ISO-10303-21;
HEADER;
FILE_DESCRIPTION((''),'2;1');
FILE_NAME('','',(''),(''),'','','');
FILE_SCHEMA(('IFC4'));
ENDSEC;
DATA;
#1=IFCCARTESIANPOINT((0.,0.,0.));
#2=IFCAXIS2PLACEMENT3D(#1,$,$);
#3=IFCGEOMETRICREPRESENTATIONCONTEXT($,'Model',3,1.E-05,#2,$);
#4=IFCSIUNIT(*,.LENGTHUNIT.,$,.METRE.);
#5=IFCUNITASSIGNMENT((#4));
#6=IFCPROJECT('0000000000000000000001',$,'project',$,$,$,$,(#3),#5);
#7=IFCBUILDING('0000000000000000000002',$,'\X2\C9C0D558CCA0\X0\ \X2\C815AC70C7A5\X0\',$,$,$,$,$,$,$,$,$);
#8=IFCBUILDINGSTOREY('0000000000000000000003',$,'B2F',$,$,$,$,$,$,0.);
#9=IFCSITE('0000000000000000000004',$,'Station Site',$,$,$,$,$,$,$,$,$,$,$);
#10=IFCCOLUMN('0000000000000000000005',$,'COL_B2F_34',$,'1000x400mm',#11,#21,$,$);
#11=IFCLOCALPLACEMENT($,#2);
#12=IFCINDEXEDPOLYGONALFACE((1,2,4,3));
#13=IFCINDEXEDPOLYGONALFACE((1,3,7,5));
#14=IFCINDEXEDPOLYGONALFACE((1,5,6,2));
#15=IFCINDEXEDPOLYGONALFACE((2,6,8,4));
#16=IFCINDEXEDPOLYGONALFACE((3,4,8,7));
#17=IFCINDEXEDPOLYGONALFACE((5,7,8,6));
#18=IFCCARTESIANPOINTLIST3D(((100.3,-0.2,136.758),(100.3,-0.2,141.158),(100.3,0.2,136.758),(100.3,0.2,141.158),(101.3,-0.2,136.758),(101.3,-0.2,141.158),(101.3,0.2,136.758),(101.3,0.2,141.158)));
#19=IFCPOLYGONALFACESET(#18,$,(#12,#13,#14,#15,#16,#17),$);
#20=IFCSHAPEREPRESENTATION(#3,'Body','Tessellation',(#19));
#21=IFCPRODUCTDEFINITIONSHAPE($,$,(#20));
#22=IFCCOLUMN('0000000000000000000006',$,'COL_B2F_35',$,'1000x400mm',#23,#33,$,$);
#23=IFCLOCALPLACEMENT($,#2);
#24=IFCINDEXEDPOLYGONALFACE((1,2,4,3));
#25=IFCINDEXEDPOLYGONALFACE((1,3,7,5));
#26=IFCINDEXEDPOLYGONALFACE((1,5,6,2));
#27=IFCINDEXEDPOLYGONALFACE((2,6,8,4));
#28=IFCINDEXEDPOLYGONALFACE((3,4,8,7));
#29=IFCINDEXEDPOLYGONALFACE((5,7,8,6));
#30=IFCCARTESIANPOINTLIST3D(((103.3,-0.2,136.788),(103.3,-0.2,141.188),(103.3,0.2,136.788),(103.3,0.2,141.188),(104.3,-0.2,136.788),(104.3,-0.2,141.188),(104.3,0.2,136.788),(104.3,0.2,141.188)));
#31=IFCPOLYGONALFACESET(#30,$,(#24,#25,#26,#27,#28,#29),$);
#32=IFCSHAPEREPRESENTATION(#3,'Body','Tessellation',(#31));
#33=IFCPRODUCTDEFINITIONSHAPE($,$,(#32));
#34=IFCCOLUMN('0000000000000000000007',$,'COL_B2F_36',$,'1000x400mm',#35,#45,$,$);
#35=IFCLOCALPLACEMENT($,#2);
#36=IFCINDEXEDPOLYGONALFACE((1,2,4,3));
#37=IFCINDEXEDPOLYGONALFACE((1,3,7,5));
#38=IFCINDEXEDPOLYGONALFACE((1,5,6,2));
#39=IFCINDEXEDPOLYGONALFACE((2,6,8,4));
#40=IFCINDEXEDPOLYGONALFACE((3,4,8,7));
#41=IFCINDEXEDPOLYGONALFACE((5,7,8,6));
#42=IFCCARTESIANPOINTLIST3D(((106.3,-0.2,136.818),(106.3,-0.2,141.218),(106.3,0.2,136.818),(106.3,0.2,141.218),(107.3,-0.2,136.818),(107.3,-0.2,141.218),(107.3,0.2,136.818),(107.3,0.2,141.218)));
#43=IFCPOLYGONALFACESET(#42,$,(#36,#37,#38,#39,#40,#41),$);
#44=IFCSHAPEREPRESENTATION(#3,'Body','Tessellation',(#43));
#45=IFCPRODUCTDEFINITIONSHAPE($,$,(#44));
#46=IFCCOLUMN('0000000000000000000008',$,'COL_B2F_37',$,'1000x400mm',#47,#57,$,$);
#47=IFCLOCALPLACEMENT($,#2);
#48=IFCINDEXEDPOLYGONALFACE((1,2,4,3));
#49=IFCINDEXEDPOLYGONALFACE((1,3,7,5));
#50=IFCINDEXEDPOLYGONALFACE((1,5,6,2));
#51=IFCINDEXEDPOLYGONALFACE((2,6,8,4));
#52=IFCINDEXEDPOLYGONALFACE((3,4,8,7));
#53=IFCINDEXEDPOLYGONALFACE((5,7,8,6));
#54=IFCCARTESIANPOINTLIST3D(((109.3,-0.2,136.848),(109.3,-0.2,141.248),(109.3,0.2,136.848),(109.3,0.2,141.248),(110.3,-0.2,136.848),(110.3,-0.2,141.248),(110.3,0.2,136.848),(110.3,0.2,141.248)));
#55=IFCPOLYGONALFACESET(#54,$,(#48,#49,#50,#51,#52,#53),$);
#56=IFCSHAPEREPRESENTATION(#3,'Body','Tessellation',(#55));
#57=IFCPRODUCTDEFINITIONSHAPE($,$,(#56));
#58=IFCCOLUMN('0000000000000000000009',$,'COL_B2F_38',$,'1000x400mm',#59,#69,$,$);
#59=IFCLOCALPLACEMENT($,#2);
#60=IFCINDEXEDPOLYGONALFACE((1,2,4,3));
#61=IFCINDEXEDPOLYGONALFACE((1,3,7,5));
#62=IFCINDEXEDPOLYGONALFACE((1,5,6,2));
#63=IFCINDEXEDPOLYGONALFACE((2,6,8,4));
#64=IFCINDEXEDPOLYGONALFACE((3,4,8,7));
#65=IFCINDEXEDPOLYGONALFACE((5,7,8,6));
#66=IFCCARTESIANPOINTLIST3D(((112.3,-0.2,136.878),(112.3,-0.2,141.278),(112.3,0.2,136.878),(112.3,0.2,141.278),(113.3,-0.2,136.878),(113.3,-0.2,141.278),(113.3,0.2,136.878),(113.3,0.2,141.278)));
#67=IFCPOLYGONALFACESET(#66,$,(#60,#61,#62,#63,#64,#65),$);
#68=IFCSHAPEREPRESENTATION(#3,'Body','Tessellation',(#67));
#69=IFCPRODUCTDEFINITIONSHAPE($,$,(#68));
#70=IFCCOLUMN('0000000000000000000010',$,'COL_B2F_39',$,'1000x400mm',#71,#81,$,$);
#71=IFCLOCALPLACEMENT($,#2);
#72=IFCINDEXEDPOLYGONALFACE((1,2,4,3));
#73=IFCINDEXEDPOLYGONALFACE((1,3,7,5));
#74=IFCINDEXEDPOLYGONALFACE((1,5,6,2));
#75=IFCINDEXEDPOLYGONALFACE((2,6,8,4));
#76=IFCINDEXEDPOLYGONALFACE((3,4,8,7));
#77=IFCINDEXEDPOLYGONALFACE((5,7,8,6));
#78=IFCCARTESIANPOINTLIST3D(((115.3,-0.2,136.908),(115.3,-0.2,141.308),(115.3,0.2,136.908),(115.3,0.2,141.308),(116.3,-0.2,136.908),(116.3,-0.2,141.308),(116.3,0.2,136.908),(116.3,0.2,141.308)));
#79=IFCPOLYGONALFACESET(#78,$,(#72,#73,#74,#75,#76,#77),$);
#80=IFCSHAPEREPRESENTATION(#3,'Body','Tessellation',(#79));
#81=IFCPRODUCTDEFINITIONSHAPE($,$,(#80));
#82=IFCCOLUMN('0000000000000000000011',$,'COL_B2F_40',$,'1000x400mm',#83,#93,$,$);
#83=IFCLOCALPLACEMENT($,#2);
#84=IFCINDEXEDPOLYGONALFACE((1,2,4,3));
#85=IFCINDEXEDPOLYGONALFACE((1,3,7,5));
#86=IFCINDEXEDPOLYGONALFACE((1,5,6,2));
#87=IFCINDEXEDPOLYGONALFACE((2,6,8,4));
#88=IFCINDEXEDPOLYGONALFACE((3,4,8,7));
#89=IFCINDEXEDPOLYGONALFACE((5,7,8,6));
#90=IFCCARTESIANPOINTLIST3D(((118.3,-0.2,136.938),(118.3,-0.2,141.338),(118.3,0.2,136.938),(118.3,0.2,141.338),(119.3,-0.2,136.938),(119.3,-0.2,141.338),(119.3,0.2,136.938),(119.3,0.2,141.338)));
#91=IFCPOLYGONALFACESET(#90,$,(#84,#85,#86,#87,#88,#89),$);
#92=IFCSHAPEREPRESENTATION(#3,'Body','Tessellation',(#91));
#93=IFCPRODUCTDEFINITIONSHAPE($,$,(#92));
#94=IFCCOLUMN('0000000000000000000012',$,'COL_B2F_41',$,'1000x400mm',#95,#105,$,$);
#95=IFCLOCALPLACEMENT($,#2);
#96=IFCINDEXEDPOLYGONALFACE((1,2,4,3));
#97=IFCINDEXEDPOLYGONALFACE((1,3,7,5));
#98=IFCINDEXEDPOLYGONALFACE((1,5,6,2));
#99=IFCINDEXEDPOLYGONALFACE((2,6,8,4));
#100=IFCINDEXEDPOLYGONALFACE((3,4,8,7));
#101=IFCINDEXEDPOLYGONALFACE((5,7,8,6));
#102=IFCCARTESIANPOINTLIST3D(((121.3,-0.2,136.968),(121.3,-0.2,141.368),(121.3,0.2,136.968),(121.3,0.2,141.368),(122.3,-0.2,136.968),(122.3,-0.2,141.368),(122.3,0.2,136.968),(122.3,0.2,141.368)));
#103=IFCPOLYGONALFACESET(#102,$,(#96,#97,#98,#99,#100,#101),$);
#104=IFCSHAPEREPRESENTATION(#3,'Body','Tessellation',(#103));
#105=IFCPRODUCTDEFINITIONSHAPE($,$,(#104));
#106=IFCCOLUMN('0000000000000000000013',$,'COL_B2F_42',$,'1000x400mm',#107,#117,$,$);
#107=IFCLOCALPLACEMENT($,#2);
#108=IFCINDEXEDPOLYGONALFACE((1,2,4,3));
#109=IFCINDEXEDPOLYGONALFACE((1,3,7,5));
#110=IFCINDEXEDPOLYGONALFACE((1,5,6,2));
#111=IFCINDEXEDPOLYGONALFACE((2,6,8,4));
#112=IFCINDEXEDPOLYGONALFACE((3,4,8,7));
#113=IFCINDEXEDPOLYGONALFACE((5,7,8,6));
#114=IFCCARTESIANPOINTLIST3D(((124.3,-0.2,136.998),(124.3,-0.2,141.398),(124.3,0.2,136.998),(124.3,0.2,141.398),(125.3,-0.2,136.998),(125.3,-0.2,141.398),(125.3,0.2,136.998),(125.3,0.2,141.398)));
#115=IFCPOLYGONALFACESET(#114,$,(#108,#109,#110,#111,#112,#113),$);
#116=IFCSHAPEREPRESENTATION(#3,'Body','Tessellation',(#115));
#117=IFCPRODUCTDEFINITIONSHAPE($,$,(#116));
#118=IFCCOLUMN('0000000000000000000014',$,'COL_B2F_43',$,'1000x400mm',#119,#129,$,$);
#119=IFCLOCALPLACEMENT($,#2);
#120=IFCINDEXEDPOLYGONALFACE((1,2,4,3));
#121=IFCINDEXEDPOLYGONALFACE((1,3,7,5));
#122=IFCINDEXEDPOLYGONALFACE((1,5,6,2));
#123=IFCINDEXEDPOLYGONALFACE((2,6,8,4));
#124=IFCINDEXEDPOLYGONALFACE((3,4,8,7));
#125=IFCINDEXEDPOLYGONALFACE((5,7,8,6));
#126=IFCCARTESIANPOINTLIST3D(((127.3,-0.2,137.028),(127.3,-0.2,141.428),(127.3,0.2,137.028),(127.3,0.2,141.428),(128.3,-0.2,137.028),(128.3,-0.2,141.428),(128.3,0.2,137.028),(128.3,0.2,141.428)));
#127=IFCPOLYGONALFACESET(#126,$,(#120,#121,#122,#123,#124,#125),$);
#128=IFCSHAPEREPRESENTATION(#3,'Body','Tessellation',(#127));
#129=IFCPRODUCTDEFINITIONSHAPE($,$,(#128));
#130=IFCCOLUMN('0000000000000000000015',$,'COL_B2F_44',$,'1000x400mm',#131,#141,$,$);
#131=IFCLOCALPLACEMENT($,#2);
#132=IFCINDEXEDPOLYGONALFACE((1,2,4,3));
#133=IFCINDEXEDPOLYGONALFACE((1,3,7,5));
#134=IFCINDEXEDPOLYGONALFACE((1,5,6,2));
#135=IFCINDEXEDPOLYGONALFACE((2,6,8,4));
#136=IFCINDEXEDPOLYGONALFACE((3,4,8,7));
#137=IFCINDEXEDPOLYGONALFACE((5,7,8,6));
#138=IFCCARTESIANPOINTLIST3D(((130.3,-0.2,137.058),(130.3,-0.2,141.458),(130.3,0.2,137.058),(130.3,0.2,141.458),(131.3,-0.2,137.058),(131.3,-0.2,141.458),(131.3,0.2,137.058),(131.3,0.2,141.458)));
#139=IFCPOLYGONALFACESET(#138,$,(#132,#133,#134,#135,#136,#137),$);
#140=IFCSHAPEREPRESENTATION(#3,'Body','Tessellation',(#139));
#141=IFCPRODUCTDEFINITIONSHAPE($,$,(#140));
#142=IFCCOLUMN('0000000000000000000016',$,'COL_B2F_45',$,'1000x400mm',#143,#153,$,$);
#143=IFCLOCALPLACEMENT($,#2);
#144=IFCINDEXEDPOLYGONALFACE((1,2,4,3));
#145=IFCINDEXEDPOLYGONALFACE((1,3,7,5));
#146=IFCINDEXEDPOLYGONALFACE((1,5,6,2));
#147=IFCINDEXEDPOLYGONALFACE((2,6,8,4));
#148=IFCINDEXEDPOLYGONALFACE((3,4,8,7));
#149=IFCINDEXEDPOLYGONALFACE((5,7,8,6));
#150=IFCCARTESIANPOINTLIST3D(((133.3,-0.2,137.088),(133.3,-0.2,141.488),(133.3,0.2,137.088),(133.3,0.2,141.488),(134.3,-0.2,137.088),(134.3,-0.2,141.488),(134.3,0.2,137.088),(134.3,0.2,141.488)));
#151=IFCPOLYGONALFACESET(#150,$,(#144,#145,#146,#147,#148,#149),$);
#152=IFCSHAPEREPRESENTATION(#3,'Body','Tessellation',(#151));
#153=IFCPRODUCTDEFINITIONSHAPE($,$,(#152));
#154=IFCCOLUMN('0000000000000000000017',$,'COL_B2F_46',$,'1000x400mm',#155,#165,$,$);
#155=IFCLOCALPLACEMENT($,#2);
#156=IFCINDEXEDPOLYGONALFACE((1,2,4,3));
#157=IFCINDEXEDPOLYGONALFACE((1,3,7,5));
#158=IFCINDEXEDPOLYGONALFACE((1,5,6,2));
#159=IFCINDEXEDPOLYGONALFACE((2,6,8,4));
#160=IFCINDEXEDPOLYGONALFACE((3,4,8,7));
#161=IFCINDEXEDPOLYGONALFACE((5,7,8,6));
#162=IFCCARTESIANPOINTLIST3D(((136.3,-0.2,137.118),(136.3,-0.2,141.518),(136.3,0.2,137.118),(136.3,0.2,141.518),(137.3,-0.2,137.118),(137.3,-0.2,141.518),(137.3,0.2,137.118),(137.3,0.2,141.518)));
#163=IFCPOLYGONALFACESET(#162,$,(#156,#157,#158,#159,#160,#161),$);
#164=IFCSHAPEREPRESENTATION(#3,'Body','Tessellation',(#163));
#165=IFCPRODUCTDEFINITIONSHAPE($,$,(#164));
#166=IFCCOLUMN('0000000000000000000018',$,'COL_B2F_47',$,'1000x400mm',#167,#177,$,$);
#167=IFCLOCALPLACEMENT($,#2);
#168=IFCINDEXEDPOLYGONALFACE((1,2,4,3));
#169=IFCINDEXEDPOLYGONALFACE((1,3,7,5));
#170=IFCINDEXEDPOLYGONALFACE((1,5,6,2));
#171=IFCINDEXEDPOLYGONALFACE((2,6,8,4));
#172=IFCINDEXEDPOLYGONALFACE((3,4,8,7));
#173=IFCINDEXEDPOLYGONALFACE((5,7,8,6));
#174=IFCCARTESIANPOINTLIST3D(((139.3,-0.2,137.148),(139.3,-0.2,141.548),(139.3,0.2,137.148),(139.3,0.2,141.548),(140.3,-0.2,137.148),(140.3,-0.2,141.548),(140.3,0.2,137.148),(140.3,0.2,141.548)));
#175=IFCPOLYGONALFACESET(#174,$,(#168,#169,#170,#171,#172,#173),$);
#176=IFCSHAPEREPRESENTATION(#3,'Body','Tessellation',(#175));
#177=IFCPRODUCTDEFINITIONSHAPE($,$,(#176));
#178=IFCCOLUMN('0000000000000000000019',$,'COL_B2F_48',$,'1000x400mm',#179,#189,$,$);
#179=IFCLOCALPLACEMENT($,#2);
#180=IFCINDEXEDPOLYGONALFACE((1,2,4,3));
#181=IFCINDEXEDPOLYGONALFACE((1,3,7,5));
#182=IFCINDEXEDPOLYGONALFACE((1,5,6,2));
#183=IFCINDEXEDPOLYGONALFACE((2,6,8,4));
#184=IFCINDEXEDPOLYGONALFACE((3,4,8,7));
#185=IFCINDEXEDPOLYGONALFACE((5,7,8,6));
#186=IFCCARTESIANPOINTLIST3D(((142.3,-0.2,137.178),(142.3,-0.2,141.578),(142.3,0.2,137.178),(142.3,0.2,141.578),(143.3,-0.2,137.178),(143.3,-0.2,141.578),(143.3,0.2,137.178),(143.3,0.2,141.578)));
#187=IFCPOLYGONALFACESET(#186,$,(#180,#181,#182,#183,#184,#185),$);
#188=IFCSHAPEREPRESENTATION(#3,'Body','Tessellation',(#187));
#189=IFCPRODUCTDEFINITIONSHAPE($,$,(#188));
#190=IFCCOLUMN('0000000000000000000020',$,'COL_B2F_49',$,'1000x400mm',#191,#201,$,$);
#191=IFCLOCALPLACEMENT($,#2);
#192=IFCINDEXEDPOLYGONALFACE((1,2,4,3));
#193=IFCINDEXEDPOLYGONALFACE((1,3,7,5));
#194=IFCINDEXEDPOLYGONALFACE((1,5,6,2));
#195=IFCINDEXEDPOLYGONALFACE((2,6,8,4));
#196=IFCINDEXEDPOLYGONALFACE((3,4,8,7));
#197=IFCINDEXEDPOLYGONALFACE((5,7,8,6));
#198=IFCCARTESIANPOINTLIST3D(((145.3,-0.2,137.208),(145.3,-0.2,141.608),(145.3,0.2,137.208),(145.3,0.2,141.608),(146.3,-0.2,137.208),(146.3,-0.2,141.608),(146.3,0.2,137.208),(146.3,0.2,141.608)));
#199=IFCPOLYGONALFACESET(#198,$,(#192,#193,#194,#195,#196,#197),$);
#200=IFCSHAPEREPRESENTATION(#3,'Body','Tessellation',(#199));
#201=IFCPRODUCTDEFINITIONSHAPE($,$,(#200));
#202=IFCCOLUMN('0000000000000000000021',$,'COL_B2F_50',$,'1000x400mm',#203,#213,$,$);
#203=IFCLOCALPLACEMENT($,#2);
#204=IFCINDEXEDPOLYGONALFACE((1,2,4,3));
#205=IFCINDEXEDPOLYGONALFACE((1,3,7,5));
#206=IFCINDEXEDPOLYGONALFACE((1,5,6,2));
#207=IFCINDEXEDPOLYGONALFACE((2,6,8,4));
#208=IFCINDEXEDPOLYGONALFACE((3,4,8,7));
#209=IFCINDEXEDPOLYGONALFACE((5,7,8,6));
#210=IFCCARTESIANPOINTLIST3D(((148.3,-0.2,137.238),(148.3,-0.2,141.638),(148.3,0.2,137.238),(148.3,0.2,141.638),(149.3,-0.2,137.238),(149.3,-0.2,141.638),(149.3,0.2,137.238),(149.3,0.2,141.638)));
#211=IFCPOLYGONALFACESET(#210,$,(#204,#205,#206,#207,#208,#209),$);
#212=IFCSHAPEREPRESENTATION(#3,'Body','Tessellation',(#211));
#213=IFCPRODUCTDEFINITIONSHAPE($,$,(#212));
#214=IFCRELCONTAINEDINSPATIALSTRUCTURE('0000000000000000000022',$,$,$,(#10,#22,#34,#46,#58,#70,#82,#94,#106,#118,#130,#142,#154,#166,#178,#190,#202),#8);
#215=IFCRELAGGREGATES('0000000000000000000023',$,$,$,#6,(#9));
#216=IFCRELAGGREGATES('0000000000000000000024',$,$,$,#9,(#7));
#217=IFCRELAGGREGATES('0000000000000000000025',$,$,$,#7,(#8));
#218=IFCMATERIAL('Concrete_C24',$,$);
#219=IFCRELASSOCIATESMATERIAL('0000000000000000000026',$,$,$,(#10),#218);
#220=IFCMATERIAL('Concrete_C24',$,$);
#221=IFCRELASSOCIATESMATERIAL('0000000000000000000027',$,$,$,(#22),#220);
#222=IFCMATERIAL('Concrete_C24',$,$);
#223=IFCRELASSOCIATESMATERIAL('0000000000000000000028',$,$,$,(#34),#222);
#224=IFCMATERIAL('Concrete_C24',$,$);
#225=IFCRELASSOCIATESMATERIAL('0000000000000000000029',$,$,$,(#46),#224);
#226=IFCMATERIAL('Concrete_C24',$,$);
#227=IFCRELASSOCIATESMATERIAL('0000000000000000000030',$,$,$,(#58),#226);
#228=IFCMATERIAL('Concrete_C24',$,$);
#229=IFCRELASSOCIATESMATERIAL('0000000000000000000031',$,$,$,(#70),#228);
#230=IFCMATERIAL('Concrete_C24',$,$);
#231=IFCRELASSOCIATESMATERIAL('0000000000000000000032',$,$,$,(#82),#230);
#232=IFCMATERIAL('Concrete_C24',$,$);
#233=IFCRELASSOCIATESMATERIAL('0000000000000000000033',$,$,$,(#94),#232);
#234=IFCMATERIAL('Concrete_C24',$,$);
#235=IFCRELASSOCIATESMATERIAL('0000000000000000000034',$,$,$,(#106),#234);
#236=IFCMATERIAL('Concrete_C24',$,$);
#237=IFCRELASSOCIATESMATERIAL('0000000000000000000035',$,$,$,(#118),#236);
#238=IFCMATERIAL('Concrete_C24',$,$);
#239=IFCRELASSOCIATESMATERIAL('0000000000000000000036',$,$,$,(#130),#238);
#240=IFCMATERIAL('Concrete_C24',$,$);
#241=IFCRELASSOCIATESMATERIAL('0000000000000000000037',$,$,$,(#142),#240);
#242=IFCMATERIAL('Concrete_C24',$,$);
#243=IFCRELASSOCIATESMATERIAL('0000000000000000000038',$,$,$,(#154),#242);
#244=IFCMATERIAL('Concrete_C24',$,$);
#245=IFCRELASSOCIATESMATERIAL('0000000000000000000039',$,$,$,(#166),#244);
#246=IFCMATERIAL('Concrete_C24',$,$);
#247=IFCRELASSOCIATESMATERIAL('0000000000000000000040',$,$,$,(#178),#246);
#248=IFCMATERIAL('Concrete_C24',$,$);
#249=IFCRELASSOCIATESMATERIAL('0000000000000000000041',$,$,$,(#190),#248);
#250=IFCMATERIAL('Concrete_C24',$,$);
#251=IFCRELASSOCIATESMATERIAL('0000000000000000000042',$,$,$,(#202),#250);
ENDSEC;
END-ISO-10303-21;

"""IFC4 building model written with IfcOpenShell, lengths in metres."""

from ifc_helpers import new_model, si_unit, frame, origin, place, context, project, spatial, rectangle, extrude, material, element, save


model = new_model("IFC4")

# Units and contexts
model_context = context("Model", 3, precision=1e-05, world=origin())
ifc_project = project(units=[si_unit("LENGTHUNIT", "METRE")], contexts=[model_context])

# Site, building, storey
site = spatial("IfcSite", under=ifc_project, Name="Station Site")
building = spatial("IfcBuilding", under=site, Name="지하철 정거장")
storey = spatial("IfcBuildingStorey", under=building, Name="B2F", Elevation=0.0)

# Columns
ifc_material_1 = material(Name="Concrete_C24")
column_1_placement = place(None, frame((100.8, 0.0, 136.758)))
element("IfcColumn", 1, at=column_1_placement, inside=storey, material=ifc_material_1, Name="COL_B2F_34", ObjectType="1000x400mm", context=model_context, shape_type="SweptSolid", body=[
    extrude(rectangle(XDim=1.0, YDim=0.4), origin(), (0.0, 0.0, 1.0), 4.4),
])
ifc_material_2 = material(Name="Concrete_C24")
column_2_placement = place(None, frame((103.8, 0.0, 136.788)))
element("IfcColumn", 2, at=column_2_placement, inside=storey, material=ifc_material_2, Name="COL_B2F_35", ObjectType="1000x400mm", context=model_context, shape_type="SweptSolid", body=[
    extrude(rectangle(XDim=1.0, YDim=0.4), origin(), (0.0, 0.0, 1.0), 4.4),
])
ifc_material_3 = material(Name="Concrete_C24")
column_3_placement = place(None, frame((106.8, 0.0, 136.818)))
element("IfcColumn", 3, at=column_3_placement, inside=storey, material=ifc_material_3, Name="COL_B2F_36", ObjectType="1000x400mm", context=model_context, shape_type="SweptSolid", body=[
    extrude(rectangle(XDim=1.0, YDim=0.4), origin(), (0.0, 0.0, 1.0), 4.4),
])
ifc_material_4 = material(Name="Concrete_C24")
column_4_placement = place(None, frame((109.8, 0.0, 136.848)))
element("IfcColumn", 4, at=column_4_placement, inside=storey, material=ifc_material_4, Name="COL_B2F_37", ObjectType="1000x400mm", context=model_context, shape_type="SweptSolid", body=[
    extrude(rectangle(XDim=1.0, YDim=0.4), origin(), (0.0, 0.0, 1.0), 4.4),
])
ifc_material_5 = material(Name="Concrete_C24")
column_5_placement = place(None, frame((112.8, 0.0, 136.878)))
element("IfcColumn", 5, at=column_5_placement, inside=storey, material=ifc_material_5, Name="COL_B2F_38", ObjectType="1000x400mm", context=model_context, shape_type="SweptSolid", body=[
    extrude(rectangle(XDim=1.0, YDim=0.4), origin(), (0.0, 0.0, 1.0), 4.4),
])
ifc_material_6 = material(Name="Concrete_C24")
column_6_placement = place(None, frame((115.8, 0.0, 136.908)))
element("IfcColumn", 6, at=column_6_placement, inside=storey, material=ifc_material_6, Name="COL_B2F_39", ObjectType="1000x400mm", context=model_context, shape_type="SweptSolid", body=[
    extrude(rectangle(XDim=1.0, YDim=0.4), origin(), (0.0, 0.0, 1.0), 4.4),
])
ifc_material_7 = material(Name="Concrete_C24")
column_7_placement = place(None, frame((118.8, 0.0, 136.938)))
element("IfcColumn", 7, at=column_7_placement, inside=storey, material=ifc_material_7, Name="COL_B2F_40", ObjectType="1000x400mm", context=model_context, shape_type="SweptSolid", body=[
    extrude(rectangle(XDim=1.0, YDim=0.4), origin(), (0.0, 0.0, 1.0), 4.4),
])
ifc_material_8 = material(Name="Concrete_C24")
column_8_placement = place(None, frame((121.8, 0.0, 136.968)))
element("IfcColumn", 8, at=column_8_placement, inside=storey, material=ifc_material_8, Name="COL_B2F_41", ObjectType="1000x400mm", context=model_context, shape_type="SweptSolid", body=[
    extrude(rectangle(XDim=1.0, YDim=0.4), origin(), (0.0, 0.0, 1.0), 4.4),
])
ifc_material_9 = material(Name="Concrete_C24")
column_9_placement = place(None, frame((124.8, 0.0, 136.998)))
element("IfcColumn", 9, at=column_9_placement, inside=storey, material=ifc_material_9, Name="COL_B2F_42", ObjectType="1000x400mm", context=model_context, shape_type="SweptSolid", body=[
    extrude(rectangle(XDim=1.0, YDim=0.4), origin(), (0.0, 0.0, 1.0), 4.4),
])
ifc_material_10 = material(Name="Concrete_C24")
column_10_placement = place(None, frame((127.8, 0.0, 137.028)))
element("IfcColumn", 10, at=column_10_placement, inside=storey, material=ifc_material_10, Name="COL_B2F_43", ObjectType="1000x400mm", context=model_context, shape_type="SweptSolid", body=[
    extrude(rectangle(XDim=1.0, YDim=0.4), origin(), (0.0, 0.0, 1.0), 4.4),
])
ifc_material_11 = material(Name="Concrete_C24")
column_11_placement = place(None, frame((130.8, 0.0, 137.058)))
element("IfcColumn", 11, at=column_11_placement, inside=storey, material=ifc_material_11, Name="COL_B2F_44", ObjectType="1000x400mm", context=model_context, shape_type="SweptSolid", body=[
    extrude(rectangle(XDim=1.0, YDim=0.4), origin(), (0.0, 0.0, 1.0), 4.4),
])
ifc_material_12 = material(Name="Concrete_C24")
column_12_placement = place(None, frame((133.8, 0.0, 137.088)))
element("IfcColumn", 12, at=column_12_placement, inside=storey, material=ifc_material_12, Name="COL_B2F_45", ObjectType="1000x400mm", context=model_context, shape_type="SweptSolid", body=[
    extrude(rectangle(XDim=1.0, YDim=0.4), origin(), (0.0, 0.0, 1.0), 4.4),
])
ifc_material_13 = material(Name="Concrete_C24")
column_13_placement = place(None, frame((136.8, 0.0, 137.118)))
element("IfcColumn", 13, at=column_13_placement, inside=storey, material=ifc_material_13, Name="COL_B2F_46", ObjectType="1000x400mm", context=model_context, shape_type="SweptSolid", body=[
    extrude(rectangle(XDim=1.0, YDim=0.4), origin(), (0.0, 0.0, 1.0), 4.4),
])
ifc_material_14 = material(Name="Concrete_C24")
column_14_placement = place(None, frame((139.8, 0.0, 137.148)))
element("IfcColumn", 14, at=column_14_placement, inside=storey, material=ifc_material_14, Name="COL_B2F_47", ObjectType="1000x400mm", context=model_context, shape_type="SweptSolid", body=[
    extrude(rectangle(XDim=1.0, YDim=0.4), origin(), (0.0, 0.0, 1.0), 4.4),
])
ifc_material_15 = material(Name="Concrete_C24")
column_15_placement = place(None, frame((142.8, 0.0, 137.178)))
element("IfcColumn", 15, at=column_15_placement, inside=storey, material=ifc_material_15, Name="COL_B2F_48", ObjectType="1000x400mm", context=model_context, shape_type="SweptSolid", body=[
    extrude(rectangle(XDim=1.0, YDim=0.4), origin(), (0.0, 0.0, 1.0), 4.4),
])
ifc_material_16 = material(Name="Concrete_C24")
column_16_placement = place(None, frame((145.8, 0.0, 137.208)))
element("IfcColumn", 16, at=column_16_placement, inside=storey, material=ifc_material_16, Name="COL_B2F_49", ObjectType="1000x400mm", context=model_context, shape_type="SweptSolid", body=[
    extrude(rectangle(XDim=1.0, YDim=0.4), origin(), (0.0, 0.0, 1.0), 4.4),
])
ifc_material_17 = material(Name="Concrete_C24")
column_17_placement = place(None, frame((148.8, 0.0, 137.238)))
element("IfcColumn", 17, at=column_17_placement, inside=storey, material=ifc_material_17, Name="COL_B2F_50", ObjectType="1000x400mm", context=model_context, shape_type="SweptSolid", body=[
    extrude(rectangle(XDim=1.0, YDim=0.4), origin(), (0.0, 0.0, 1.0), 4.4),
])

save(model, "model.ifc")
